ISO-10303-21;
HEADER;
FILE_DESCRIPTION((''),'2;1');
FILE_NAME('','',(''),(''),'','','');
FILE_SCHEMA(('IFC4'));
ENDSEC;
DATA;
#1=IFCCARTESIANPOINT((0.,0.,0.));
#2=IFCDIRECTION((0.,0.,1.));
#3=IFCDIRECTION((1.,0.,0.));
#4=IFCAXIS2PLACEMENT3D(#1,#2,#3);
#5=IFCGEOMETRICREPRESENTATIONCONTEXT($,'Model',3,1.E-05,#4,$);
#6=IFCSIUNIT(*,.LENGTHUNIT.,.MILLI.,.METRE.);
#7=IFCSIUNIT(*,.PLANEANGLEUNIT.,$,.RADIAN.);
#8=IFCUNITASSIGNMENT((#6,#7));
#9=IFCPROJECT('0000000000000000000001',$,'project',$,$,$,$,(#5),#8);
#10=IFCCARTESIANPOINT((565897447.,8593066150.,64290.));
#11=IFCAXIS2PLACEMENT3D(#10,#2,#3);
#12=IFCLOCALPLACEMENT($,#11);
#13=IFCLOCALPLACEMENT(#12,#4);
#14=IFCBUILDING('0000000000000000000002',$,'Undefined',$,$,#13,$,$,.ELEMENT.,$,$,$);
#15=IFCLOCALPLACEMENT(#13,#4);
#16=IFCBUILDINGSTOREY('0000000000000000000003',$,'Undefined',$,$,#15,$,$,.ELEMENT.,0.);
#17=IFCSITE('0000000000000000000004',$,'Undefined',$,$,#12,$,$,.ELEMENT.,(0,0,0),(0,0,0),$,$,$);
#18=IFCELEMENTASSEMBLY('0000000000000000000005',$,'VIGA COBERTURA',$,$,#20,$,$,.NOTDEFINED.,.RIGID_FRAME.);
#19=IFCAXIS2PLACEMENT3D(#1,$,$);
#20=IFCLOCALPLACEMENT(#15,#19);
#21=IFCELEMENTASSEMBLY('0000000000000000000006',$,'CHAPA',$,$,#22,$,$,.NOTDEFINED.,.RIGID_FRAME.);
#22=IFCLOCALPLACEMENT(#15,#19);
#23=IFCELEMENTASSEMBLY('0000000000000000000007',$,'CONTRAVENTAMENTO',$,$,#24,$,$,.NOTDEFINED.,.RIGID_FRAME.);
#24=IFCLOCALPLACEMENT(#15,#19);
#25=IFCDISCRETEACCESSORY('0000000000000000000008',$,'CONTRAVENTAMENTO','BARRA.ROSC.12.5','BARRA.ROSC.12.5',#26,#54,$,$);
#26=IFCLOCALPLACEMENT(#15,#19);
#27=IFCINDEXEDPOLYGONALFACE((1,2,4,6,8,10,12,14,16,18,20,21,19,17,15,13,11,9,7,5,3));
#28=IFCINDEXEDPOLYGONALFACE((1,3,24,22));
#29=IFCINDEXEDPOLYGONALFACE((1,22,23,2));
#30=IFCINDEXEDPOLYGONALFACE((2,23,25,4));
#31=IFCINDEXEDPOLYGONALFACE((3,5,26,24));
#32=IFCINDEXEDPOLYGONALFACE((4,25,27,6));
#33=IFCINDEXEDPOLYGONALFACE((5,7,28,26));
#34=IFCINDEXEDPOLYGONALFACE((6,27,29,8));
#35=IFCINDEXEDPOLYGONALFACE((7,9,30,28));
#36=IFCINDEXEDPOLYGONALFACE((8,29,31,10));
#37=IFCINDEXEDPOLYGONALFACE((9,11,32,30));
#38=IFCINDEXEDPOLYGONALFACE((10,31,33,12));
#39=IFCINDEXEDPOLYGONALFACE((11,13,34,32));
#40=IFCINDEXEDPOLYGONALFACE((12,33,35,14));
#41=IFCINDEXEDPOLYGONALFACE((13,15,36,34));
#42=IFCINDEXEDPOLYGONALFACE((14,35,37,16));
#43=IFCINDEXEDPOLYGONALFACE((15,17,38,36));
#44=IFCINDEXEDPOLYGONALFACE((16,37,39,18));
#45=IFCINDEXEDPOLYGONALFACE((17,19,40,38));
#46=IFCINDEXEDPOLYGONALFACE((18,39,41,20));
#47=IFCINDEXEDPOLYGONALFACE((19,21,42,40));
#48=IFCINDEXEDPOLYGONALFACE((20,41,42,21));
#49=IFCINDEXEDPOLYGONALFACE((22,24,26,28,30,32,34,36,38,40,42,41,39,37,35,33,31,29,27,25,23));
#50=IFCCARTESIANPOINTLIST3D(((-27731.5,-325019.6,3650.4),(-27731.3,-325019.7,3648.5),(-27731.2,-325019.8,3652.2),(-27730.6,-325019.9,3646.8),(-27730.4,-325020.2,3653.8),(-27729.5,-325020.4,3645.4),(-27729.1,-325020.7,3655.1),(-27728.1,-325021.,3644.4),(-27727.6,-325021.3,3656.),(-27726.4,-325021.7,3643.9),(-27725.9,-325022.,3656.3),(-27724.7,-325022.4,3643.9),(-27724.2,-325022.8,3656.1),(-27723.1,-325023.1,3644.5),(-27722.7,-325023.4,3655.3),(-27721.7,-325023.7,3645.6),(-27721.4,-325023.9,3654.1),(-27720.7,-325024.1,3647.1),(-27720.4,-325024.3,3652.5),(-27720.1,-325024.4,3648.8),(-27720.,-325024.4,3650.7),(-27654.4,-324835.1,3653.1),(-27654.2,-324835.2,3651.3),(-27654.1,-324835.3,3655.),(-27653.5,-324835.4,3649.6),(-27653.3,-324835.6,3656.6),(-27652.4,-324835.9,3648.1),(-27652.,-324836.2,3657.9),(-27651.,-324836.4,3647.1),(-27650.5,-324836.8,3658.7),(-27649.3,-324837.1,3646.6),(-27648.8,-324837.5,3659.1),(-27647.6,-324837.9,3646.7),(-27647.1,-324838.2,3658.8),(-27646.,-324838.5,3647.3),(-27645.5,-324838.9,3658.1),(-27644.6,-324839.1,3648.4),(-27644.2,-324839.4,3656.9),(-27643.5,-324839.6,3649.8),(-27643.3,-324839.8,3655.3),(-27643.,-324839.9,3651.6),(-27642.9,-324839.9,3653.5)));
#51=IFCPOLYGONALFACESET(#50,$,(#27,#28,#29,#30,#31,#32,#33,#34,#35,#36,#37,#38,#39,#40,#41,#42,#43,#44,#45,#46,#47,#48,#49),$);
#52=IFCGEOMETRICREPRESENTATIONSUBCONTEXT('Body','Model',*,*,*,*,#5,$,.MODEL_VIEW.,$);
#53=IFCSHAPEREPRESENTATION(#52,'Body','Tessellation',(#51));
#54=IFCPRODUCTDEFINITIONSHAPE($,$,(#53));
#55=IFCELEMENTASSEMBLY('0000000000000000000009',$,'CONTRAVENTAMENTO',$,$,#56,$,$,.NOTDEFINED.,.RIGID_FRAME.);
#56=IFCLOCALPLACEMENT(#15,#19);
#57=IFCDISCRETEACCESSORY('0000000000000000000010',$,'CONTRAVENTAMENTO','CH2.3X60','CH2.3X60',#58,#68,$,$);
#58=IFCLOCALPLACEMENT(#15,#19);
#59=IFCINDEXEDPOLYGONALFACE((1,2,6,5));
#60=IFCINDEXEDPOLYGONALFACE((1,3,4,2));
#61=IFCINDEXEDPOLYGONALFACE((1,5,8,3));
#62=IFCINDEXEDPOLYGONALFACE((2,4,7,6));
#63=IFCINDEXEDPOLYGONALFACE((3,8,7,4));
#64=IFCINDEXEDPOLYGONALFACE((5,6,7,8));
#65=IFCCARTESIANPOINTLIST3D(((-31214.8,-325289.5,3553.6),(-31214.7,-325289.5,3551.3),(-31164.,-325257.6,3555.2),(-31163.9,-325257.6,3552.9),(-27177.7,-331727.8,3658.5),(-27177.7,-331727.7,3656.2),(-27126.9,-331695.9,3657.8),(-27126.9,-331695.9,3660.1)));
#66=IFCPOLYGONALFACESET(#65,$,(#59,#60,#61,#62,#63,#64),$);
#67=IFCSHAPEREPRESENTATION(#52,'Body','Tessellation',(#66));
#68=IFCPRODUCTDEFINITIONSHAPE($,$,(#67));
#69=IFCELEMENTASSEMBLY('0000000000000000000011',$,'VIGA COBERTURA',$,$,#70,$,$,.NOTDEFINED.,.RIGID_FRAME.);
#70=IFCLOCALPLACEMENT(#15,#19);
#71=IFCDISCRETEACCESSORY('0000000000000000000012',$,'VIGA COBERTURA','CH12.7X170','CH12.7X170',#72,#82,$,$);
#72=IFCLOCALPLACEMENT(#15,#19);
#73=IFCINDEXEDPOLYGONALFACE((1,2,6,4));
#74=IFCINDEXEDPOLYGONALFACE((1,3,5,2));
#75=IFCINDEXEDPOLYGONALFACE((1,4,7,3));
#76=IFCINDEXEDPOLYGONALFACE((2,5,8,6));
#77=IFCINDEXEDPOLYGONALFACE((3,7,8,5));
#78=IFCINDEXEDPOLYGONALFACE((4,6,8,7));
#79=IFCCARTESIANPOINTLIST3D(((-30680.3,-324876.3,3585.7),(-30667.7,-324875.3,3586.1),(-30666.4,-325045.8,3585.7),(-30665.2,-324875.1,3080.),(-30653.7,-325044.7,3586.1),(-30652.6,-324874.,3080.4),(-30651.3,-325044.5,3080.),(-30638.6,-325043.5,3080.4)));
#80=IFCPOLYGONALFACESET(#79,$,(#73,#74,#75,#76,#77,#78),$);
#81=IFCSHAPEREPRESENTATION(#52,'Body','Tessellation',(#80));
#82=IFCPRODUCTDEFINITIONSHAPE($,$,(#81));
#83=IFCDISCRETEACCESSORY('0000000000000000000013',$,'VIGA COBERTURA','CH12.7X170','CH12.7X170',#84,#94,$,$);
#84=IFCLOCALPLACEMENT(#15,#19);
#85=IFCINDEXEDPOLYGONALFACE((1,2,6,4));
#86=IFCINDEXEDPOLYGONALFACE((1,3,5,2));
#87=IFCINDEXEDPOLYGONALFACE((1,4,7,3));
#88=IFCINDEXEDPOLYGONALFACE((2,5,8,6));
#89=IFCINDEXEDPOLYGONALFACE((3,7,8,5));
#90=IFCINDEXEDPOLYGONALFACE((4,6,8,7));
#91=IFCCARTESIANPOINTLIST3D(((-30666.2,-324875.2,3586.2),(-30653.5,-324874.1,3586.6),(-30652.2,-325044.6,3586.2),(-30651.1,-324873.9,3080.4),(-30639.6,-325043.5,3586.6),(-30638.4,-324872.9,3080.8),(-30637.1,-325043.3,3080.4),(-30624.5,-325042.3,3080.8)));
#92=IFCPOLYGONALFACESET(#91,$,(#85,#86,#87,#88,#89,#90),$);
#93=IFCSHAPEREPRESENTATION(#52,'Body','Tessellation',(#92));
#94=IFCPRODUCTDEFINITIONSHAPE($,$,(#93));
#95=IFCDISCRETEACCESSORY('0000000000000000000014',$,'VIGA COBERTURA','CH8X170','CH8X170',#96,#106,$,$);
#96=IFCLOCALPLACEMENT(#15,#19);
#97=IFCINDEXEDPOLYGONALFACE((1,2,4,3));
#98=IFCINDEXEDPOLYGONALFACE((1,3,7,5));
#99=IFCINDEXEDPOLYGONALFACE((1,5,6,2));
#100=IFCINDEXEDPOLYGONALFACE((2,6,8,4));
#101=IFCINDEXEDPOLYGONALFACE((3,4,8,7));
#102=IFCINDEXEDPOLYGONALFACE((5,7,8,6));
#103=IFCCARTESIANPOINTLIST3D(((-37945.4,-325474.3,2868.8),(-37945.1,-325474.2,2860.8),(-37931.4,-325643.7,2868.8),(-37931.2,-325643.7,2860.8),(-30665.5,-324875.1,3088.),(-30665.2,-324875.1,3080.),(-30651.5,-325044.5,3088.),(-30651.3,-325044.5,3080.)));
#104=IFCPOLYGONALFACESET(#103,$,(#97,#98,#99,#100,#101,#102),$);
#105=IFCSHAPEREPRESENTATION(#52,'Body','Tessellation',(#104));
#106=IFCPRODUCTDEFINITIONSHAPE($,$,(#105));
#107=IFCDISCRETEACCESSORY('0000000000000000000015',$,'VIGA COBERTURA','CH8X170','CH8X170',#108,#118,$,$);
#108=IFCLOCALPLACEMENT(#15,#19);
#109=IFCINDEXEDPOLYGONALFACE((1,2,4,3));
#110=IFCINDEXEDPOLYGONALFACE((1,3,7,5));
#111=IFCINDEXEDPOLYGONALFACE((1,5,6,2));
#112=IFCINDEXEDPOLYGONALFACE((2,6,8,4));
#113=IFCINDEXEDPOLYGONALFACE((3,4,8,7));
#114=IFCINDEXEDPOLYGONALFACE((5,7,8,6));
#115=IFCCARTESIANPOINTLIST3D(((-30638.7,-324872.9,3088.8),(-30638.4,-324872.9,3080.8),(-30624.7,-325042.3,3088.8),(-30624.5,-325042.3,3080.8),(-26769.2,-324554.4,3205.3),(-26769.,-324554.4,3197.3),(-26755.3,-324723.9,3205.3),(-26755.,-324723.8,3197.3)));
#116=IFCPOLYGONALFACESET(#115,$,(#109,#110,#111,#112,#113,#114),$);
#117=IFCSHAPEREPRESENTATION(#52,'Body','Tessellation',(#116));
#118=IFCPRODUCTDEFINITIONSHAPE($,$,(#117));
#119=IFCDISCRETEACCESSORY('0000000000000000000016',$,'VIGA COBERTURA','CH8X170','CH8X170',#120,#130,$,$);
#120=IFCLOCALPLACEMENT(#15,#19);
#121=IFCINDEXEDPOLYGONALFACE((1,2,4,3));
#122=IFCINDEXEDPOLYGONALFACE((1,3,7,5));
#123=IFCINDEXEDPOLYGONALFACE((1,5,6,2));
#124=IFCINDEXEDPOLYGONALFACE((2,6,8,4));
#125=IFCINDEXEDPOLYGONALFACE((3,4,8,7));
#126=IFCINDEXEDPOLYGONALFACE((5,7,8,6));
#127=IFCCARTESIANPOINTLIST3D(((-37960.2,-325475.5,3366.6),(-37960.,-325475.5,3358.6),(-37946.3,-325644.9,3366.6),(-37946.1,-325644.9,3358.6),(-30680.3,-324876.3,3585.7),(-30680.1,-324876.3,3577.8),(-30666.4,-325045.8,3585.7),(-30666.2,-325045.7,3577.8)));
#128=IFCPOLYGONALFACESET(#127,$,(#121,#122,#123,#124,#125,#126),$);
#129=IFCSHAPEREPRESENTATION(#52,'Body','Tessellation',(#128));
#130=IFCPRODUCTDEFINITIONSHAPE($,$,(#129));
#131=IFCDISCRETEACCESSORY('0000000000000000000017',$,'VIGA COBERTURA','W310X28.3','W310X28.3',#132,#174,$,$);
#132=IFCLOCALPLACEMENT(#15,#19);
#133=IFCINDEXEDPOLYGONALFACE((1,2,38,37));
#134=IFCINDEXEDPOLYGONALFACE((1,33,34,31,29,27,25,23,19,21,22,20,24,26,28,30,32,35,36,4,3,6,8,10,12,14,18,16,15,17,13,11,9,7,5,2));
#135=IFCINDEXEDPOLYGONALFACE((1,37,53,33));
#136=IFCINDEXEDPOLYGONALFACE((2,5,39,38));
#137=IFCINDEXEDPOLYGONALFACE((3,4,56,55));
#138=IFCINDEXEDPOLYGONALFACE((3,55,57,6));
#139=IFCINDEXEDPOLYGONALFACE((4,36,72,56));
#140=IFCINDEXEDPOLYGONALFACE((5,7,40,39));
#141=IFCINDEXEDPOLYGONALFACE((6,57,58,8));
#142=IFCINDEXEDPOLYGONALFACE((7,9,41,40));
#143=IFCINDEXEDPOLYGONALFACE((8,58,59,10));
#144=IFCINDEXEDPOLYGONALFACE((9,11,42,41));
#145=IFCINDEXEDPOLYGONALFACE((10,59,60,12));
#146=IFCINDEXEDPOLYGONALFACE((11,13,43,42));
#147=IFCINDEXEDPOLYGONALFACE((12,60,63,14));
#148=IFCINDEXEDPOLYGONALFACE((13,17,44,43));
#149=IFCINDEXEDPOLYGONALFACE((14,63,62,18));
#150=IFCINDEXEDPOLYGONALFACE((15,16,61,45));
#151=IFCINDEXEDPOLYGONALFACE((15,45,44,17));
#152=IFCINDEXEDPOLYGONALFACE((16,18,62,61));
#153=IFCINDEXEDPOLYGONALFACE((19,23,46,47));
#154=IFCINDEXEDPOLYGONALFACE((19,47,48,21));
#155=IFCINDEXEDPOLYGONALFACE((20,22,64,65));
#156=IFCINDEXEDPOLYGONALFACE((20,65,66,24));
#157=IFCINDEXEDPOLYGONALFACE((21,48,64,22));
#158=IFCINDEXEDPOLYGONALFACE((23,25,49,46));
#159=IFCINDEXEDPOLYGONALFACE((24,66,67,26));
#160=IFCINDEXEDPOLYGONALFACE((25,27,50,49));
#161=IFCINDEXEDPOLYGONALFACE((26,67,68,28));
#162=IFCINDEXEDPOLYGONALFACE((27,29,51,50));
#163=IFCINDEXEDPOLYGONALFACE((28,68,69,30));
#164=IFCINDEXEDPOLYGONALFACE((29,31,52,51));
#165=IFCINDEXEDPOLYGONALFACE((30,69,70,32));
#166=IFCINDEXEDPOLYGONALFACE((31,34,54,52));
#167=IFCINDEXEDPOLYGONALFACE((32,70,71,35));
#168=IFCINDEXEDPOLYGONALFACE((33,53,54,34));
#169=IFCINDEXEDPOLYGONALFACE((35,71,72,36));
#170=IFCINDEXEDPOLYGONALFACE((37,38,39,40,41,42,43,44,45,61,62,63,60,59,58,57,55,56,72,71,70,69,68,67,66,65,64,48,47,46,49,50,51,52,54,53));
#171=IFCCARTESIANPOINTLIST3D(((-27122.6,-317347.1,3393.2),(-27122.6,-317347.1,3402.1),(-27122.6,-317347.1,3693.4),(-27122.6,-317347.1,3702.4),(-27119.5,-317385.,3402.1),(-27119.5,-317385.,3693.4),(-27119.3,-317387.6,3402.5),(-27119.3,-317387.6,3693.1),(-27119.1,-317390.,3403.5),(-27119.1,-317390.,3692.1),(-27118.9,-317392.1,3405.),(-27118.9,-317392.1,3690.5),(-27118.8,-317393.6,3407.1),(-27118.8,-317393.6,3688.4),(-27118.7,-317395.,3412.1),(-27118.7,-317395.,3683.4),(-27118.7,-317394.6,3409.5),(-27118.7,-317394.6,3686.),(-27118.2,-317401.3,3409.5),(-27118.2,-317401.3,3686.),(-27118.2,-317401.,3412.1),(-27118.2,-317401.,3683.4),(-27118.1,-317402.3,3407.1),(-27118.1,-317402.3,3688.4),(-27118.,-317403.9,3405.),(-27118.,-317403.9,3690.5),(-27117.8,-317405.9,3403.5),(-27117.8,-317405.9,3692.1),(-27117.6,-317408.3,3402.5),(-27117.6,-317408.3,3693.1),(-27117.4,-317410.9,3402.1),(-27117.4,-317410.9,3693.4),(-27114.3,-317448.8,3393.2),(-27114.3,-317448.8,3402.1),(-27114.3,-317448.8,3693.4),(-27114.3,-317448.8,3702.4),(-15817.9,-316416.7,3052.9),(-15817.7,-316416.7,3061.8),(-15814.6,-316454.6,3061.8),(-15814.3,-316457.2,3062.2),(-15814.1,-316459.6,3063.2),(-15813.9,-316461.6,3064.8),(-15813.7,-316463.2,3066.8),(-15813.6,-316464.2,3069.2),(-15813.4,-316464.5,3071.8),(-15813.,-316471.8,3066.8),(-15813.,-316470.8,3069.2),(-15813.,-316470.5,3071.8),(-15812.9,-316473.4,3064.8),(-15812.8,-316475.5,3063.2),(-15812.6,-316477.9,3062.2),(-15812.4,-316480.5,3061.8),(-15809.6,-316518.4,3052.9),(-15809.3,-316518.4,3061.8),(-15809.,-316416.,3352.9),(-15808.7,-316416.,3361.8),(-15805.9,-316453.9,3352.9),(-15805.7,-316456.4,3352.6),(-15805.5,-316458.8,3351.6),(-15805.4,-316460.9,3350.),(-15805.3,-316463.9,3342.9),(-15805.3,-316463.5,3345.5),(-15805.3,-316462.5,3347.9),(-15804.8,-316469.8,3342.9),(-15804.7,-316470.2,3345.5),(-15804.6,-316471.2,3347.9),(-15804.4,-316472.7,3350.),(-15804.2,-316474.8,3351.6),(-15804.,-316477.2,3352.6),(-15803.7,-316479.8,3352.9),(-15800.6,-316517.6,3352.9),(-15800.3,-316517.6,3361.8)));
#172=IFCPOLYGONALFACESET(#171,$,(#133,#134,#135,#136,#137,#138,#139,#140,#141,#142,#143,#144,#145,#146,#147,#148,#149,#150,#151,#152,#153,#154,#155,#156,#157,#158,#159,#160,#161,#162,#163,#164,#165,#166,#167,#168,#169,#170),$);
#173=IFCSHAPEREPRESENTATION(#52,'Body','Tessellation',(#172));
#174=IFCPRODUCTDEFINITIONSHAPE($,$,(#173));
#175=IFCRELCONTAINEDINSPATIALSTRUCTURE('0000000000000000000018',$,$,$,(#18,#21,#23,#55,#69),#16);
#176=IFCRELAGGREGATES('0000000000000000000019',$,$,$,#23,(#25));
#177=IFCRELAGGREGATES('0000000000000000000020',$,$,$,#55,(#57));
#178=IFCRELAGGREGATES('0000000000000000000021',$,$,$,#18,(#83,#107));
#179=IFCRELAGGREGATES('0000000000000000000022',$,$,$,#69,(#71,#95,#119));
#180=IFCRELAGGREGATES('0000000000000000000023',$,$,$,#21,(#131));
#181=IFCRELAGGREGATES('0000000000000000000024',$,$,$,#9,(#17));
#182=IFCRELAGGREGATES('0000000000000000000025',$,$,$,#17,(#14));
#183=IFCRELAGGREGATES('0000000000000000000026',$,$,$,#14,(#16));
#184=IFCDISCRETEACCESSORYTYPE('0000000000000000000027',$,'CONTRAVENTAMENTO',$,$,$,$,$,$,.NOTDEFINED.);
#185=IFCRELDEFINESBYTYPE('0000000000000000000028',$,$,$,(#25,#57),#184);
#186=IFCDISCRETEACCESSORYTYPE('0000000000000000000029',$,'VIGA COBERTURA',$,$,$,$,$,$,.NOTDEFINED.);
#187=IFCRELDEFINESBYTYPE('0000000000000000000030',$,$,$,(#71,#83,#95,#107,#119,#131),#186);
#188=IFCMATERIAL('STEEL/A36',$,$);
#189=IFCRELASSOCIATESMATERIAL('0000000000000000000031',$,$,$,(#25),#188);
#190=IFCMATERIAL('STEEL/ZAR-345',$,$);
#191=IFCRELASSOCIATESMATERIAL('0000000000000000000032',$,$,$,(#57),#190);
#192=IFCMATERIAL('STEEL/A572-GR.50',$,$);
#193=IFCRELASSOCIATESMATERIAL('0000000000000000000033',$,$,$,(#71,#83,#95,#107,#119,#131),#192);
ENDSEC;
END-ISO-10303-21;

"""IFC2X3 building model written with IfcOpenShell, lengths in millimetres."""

from ifc_helpers import new_model, si_unit, frame, origin_with_axes, origin_2d_with_axis, place, context, subcontext, project, spatial, polyline, rectangle, circle, i_section, outline, extrude, clip, halfspace, material, type_object, element, aggregate, save


model = new_model("IFC2X3")

# Units and contexts
model_context = context("Model", 3, precision=1e-05, world=origin_with_axes())
body_context = subcontext(model_context, "Body", "Model", "MODEL_VIEW")
ifc_project = project(units=[si_unit("LENGTHUNIT", "METRE", prefix="MILLI"), si_unit("PLANEANGLEUNIT", "RADIAN")], contexts=[model_context])

# Site, building, storey
site_placement = place(None, frame((565897447.0, 8593066150.0, 64290.0), z_axis=(0.0, 0.0, 1.0), x_axis=(1.0, 0.0, 0.0)))
site = spatial("IfcSite", under=ifc_project, at=site_placement, Name="Undefined", CompositionType="ELEMENT", RefLatitude=(0, 0, 0), RefLongitude=(0, 0, 0))
building_placement = place(site_placement, origin_with_axes())
building = spatial("IfcBuilding", under=site, at=building_placement, Name="Undefined", CompositionType="ELEMENT")
storey_placement = place(building_placement, origin_with_axes())
storey = spatial("IfcBuildingStorey", under=building, at=storey_placement, Name="Undefined", CompositionType="ELEMENT", Elevation=0.0)

# Shared definitions
ifc_material_1 = material(Name="STEEL/A572-GR.50")

# Shared definitions
ifc_material_2 = material(Name="STEEL/A36")

# Element assembly
assembly_1_placement = place(storey_placement, origin_with_axes())
assembly_1 = element("IfcElementAssembly", 1, at=assembly_1_placement, inside=storey, Name="VIGA COBERTURA", AssemblyPlace="NOTDEFINED", PredefinedType="RIGID_FRAME")

# Element assembly
assembly_2_placement = place(storey_placement, origin_with_axes())
assembly_2 = element("IfcElementAssembly", 2, at=assembly_2_placement, inside=storey, Name="CHAPA", AssemblyPlace="NOTDEFINED", PredefinedType="RIGID_FRAME")

# Element assemblies, discrete accessories
assembly_3_placement = place(storey_placement, origin_with_axes())
assembly_3 = element("IfcElementAssembly", 3, at=assembly_3_placement, inside=storey, Name="CONTRAVENTAMENTO", AssemblyPlace="NOTDEFINED", PredefinedType="RIGID_FRAME")
discrete_accessory_type_1 = type_object("IfcDiscreteAccessoryType", Name="CONTRAVENTAMENTO")
discrete_accessory_1_placement = place(assembly_3_placement, frame((-27648.6, -324837.5, 3652.8), z_axis=(0.922203, -0.385776, 0.026799), x_axis=(-0.385536, -0.92259, -0.013797)))
discrete_accessory_1 = element("IfcDiscreteAccessory", 4, at=discrete_accessory_1_placement, type_object=discrete_accessory_type_1, material=ifc_material_2, Name="CONTRAVENTAMENTO", Description="BARRA.ROSC.12.5", ObjectType="BARRA.ROSC.12.5", context=body_context, shape_type="SweptSolid", body=[
    extrude(circle(Radius=6.2, at=origin_2d_with_axis()), frame((200.0, 0.0, 0.0), z_axis=(-1.0, 0.0, 0.0), x_axis=(0.0, -1.0, 0.0)), (0.0, 0.0, 1.0), 200.0),
])
aggregate(assembly_3, [discrete_accessory_1])
assembly_4_placement = place(storey_placement, origin_with_axes())
assembly_4 = element("IfcElementAssembly", 5, at=assembly_4_placement, inside=storey, Name="CONTRAVENTAMENTO", AssemblyPlace="NOTDEFINED", PredefinedType="RIGID_FRAME")
ifc_material_3 = material(Name="STEEL/ZAR-345")
discrete_accessory_2_placement = place(assembly_4_placement, frame((-31189.3, -325273.5, 3553.3), z_axis=(-0.030034, -0.002553, 0.999546), x_axis=(0.53119, -0.84714, 0.013797)))
discrete_accessory_2 = element("IfcDiscreteAccessory", 6, at=discrete_accessory_2_placement, type_object=discrete_accessory_type_1, material=ifc_material_3, Name="CONTRAVENTAMENTO", Description="CH2.3X60", ObjectType="CH2.3X60", context=body_context, shape_type="SweptSolid", body=[
    extrude(outline(polyline([(0.0, 30.0), (7600.0, 30.0), (7600.0, -30.0), (0.0, -30.0), (0.0, 30.0)])), frame((0.0, 0.0, -1.1), z_axis=(0.0, 0.0, 1.0), x_axis=(1.0, 0.0, 0.0)), (0.0, 0.0, 1.0), 2.3),
])
aggregate(assembly_4, [discrete_accessory_2])
assembly_5_placement = place(storey_placement, origin_with_axes())
assembly_5 = element("IfcElementAssembly", 7, at=assembly_5_placement, inside=storey, Name="VIGA COBERTURA", AssemblyPlace="NOTDEFINED", PredefinedType="RIGID_FRAME")
discrete_accessory_type_2 = type_object("IfcDiscreteAccessoryType", Name="VIGA COBERTURA")
discrete_accessory_3_placement = place(assembly_5_placement, frame((-30667.0, -324960.5, 3585.9), z_axis=(0.082025, -0.99663, 0.0), x_axis=(0.029885, 0.00246, -0.99955)))
discrete_accessory_3 = element("IfcDiscreteAccessory", 8, at=discrete_accessory_3_placement, type_object=discrete_accessory_type_2, material=ifc_material_1, Name="VIGA COBERTURA", Description="CH12.7X170", ObjectType="CH12.7X170", context=body_context, shape_type="SweptSolid", body=[
    extrude(rectangle(XDim=12.7, YDim=170.0, at=origin_2d_with_axis()), frame((506.0, 0.0, 0.0), z_axis=(-1.0, 0.0, 0.0), x_axis=(0.0, -1.0, 0.0)), (0.0, 0.0, 1.0), 506.0),
])

# Discrete accessories
discrete_accessory_4_placement = place(assembly_1_placement, frame((-30652.9, -324959.4, 3586.4), z_axis=(0.082025, -0.99663, 0.0), x_axis=(0.029885, 0.00246, -0.99955)))
discrete_accessory_4 = element("IfcDiscreteAccessory", 9, at=discrete_accessory_4_placement, type_object=discrete_accessory_type_2, material=ifc_material_1, Name="VIGA COBERTURA", Description="CH12.7X170", ObjectType="CH12.7X170", context=body_context, shape_type="SweptSolid", body=[
    extrude(rectangle(XDim=12.7, YDim=170.0, at=origin_2d_with_axis()), frame((506.0, 0.0, 0.0), z_axis=(-1.0, 0.0, 0.0), x_axis=(0.0, -1.0, 0.0)), (0.0, 0.0, 1.0), 506.0),
])
discrete_accessory_5_placement = place(assembly_5_placement, frame((-30658.4, -324959.8, 3084.0), z_axis=(0.029885, 0.00246, -0.99955), x_axis=(-0.996182, -0.081989, -0.029987)))
discrete_accessory_5 = element("IfcDiscreteAccessory", 10, at=discrete_accessory_5_placement, type_object=discrete_accessory_type_2, material=ifc_material_1, Name="VIGA COBERTURA", Description="CH8X170", ObjectType="CH8X170", context=body_context, shape_type="SweptSolid", body=[
    extrude(outline(polyline([(7307.8, 85.0), (7307.8, -85.0), (0.0, -85.0), (0.0, 85.0), (7307.8, 85.0)])), frame((0.0, 0.0, -4.0), z_axis=(0.0, 0.0, 1.0), x_axis=(1.0, 0.0, 0.0)), (0.0, 0.0, 1.0), 8.0),
])
discrete_accessory_6_placement = place(assembly_1_placement, frame((-26762.1, -324639.1, 3201.3), z_axis=(0.029885, 0.00246, -0.99955), x_axis=(-0.996182, -0.081989, -0.029987)))
discrete_accessory_6 = element("IfcDiscreteAccessory", 11, at=discrete_accessory_6_placement, type_object=discrete_accessory_type_2, material=ifc_material_1, Name="VIGA COBERTURA", Description="CH8X170", ObjectType="CH8X170", context=body_context, shape_type="SweptSolid", body=[
    extrude(outline(polyline([(3884.3, 85.0), (3884.3, -85.0), (0.0, -85.0), (0.0, 85.0), (3884.3, 85.0)])), frame((0.0, 0.0, -4.0), z_axis=(0.0, 0.0, 1.0), x_axis=(1.0, 0.0, 0.0)), (0.0, 0.0, 1.0), 8.0),
])
aggregate(assembly_1, [discrete_accessory_4, discrete_accessory_6])
discrete_accessory_7_placement = place(assembly_5_placement, frame((-30673.2, -324961.0, 3581.7), z_axis=(0.029885, 0.00246, -0.99955), x_axis=(-0.996182, -0.081989, -0.029987)))
discrete_accessory_7 = element("IfcDiscreteAccessory", 12, at=discrete_accessory_7_placement, type_object=discrete_accessory_type_2, material=ifc_material_1, Name="VIGA COBERTURA", Description="CH8X170", ObjectType="CH8X170", context=body_context, shape_type="SweptSolid", body=[
    extrude(outline(polyline([(7307.8, 85.0), (7307.8, -85.0), (0.0, -85.0), (0.0, 85.0), (7307.8, 85.0)])), frame((0.0, 0.0, -4.0), z_axis=(0.0, 0.0, 1.0), x_axis=(1.0, 0.0, 0.0)), (0.0, 0.0, 1.0), 8.0),
])
aggregate(assembly_5, [discrete_accessory_3, discrete_accessory_5, discrete_accessory_7])
discrete_accessory_8_placement = place(assembly_2_placement, frame((-27135.7, -317399.4, 3548.3), z_axis=(-0.029885, -0.00246, -0.99955), x_axis=(0.996182, 0.081989, -0.029987)))
discrete_accessory_8 = element("IfcDiscreteAccessory", 13, at=discrete_accessory_8_placement, type_object=discrete_accessory_type_2, material=ifc_material_1, Name="VIGA COBERTURA", Description="W310X28.3", ObjectType="W310X28.3", context=body_context, shape_type="Clipping", body=[
    clip(extrude(i_section(OverallWidth=102.0, OverallDepth=309.0, WebThickness=6.0, FlangeThickness=8.9, FilletRadius=10.0, at=origin_2d_with_axis()), frame((11370.0, 0.0, 0.0), z_axis=(-1.0, 0.0, 0.0), x_axis=(0.0, -1.0, 0.0)), (0.0, 0.0, 1.0), 11370.0), halfspace(frame((12.7, -51.0, -154.5), z_axis=(-0.99955, 0.0, 0.029987), x_axis=(0.0, 1.0, 0.0)), False)),
])
aggregate(assembly_2, [discrete_accessory_8])

save(model, "model.ifc")
